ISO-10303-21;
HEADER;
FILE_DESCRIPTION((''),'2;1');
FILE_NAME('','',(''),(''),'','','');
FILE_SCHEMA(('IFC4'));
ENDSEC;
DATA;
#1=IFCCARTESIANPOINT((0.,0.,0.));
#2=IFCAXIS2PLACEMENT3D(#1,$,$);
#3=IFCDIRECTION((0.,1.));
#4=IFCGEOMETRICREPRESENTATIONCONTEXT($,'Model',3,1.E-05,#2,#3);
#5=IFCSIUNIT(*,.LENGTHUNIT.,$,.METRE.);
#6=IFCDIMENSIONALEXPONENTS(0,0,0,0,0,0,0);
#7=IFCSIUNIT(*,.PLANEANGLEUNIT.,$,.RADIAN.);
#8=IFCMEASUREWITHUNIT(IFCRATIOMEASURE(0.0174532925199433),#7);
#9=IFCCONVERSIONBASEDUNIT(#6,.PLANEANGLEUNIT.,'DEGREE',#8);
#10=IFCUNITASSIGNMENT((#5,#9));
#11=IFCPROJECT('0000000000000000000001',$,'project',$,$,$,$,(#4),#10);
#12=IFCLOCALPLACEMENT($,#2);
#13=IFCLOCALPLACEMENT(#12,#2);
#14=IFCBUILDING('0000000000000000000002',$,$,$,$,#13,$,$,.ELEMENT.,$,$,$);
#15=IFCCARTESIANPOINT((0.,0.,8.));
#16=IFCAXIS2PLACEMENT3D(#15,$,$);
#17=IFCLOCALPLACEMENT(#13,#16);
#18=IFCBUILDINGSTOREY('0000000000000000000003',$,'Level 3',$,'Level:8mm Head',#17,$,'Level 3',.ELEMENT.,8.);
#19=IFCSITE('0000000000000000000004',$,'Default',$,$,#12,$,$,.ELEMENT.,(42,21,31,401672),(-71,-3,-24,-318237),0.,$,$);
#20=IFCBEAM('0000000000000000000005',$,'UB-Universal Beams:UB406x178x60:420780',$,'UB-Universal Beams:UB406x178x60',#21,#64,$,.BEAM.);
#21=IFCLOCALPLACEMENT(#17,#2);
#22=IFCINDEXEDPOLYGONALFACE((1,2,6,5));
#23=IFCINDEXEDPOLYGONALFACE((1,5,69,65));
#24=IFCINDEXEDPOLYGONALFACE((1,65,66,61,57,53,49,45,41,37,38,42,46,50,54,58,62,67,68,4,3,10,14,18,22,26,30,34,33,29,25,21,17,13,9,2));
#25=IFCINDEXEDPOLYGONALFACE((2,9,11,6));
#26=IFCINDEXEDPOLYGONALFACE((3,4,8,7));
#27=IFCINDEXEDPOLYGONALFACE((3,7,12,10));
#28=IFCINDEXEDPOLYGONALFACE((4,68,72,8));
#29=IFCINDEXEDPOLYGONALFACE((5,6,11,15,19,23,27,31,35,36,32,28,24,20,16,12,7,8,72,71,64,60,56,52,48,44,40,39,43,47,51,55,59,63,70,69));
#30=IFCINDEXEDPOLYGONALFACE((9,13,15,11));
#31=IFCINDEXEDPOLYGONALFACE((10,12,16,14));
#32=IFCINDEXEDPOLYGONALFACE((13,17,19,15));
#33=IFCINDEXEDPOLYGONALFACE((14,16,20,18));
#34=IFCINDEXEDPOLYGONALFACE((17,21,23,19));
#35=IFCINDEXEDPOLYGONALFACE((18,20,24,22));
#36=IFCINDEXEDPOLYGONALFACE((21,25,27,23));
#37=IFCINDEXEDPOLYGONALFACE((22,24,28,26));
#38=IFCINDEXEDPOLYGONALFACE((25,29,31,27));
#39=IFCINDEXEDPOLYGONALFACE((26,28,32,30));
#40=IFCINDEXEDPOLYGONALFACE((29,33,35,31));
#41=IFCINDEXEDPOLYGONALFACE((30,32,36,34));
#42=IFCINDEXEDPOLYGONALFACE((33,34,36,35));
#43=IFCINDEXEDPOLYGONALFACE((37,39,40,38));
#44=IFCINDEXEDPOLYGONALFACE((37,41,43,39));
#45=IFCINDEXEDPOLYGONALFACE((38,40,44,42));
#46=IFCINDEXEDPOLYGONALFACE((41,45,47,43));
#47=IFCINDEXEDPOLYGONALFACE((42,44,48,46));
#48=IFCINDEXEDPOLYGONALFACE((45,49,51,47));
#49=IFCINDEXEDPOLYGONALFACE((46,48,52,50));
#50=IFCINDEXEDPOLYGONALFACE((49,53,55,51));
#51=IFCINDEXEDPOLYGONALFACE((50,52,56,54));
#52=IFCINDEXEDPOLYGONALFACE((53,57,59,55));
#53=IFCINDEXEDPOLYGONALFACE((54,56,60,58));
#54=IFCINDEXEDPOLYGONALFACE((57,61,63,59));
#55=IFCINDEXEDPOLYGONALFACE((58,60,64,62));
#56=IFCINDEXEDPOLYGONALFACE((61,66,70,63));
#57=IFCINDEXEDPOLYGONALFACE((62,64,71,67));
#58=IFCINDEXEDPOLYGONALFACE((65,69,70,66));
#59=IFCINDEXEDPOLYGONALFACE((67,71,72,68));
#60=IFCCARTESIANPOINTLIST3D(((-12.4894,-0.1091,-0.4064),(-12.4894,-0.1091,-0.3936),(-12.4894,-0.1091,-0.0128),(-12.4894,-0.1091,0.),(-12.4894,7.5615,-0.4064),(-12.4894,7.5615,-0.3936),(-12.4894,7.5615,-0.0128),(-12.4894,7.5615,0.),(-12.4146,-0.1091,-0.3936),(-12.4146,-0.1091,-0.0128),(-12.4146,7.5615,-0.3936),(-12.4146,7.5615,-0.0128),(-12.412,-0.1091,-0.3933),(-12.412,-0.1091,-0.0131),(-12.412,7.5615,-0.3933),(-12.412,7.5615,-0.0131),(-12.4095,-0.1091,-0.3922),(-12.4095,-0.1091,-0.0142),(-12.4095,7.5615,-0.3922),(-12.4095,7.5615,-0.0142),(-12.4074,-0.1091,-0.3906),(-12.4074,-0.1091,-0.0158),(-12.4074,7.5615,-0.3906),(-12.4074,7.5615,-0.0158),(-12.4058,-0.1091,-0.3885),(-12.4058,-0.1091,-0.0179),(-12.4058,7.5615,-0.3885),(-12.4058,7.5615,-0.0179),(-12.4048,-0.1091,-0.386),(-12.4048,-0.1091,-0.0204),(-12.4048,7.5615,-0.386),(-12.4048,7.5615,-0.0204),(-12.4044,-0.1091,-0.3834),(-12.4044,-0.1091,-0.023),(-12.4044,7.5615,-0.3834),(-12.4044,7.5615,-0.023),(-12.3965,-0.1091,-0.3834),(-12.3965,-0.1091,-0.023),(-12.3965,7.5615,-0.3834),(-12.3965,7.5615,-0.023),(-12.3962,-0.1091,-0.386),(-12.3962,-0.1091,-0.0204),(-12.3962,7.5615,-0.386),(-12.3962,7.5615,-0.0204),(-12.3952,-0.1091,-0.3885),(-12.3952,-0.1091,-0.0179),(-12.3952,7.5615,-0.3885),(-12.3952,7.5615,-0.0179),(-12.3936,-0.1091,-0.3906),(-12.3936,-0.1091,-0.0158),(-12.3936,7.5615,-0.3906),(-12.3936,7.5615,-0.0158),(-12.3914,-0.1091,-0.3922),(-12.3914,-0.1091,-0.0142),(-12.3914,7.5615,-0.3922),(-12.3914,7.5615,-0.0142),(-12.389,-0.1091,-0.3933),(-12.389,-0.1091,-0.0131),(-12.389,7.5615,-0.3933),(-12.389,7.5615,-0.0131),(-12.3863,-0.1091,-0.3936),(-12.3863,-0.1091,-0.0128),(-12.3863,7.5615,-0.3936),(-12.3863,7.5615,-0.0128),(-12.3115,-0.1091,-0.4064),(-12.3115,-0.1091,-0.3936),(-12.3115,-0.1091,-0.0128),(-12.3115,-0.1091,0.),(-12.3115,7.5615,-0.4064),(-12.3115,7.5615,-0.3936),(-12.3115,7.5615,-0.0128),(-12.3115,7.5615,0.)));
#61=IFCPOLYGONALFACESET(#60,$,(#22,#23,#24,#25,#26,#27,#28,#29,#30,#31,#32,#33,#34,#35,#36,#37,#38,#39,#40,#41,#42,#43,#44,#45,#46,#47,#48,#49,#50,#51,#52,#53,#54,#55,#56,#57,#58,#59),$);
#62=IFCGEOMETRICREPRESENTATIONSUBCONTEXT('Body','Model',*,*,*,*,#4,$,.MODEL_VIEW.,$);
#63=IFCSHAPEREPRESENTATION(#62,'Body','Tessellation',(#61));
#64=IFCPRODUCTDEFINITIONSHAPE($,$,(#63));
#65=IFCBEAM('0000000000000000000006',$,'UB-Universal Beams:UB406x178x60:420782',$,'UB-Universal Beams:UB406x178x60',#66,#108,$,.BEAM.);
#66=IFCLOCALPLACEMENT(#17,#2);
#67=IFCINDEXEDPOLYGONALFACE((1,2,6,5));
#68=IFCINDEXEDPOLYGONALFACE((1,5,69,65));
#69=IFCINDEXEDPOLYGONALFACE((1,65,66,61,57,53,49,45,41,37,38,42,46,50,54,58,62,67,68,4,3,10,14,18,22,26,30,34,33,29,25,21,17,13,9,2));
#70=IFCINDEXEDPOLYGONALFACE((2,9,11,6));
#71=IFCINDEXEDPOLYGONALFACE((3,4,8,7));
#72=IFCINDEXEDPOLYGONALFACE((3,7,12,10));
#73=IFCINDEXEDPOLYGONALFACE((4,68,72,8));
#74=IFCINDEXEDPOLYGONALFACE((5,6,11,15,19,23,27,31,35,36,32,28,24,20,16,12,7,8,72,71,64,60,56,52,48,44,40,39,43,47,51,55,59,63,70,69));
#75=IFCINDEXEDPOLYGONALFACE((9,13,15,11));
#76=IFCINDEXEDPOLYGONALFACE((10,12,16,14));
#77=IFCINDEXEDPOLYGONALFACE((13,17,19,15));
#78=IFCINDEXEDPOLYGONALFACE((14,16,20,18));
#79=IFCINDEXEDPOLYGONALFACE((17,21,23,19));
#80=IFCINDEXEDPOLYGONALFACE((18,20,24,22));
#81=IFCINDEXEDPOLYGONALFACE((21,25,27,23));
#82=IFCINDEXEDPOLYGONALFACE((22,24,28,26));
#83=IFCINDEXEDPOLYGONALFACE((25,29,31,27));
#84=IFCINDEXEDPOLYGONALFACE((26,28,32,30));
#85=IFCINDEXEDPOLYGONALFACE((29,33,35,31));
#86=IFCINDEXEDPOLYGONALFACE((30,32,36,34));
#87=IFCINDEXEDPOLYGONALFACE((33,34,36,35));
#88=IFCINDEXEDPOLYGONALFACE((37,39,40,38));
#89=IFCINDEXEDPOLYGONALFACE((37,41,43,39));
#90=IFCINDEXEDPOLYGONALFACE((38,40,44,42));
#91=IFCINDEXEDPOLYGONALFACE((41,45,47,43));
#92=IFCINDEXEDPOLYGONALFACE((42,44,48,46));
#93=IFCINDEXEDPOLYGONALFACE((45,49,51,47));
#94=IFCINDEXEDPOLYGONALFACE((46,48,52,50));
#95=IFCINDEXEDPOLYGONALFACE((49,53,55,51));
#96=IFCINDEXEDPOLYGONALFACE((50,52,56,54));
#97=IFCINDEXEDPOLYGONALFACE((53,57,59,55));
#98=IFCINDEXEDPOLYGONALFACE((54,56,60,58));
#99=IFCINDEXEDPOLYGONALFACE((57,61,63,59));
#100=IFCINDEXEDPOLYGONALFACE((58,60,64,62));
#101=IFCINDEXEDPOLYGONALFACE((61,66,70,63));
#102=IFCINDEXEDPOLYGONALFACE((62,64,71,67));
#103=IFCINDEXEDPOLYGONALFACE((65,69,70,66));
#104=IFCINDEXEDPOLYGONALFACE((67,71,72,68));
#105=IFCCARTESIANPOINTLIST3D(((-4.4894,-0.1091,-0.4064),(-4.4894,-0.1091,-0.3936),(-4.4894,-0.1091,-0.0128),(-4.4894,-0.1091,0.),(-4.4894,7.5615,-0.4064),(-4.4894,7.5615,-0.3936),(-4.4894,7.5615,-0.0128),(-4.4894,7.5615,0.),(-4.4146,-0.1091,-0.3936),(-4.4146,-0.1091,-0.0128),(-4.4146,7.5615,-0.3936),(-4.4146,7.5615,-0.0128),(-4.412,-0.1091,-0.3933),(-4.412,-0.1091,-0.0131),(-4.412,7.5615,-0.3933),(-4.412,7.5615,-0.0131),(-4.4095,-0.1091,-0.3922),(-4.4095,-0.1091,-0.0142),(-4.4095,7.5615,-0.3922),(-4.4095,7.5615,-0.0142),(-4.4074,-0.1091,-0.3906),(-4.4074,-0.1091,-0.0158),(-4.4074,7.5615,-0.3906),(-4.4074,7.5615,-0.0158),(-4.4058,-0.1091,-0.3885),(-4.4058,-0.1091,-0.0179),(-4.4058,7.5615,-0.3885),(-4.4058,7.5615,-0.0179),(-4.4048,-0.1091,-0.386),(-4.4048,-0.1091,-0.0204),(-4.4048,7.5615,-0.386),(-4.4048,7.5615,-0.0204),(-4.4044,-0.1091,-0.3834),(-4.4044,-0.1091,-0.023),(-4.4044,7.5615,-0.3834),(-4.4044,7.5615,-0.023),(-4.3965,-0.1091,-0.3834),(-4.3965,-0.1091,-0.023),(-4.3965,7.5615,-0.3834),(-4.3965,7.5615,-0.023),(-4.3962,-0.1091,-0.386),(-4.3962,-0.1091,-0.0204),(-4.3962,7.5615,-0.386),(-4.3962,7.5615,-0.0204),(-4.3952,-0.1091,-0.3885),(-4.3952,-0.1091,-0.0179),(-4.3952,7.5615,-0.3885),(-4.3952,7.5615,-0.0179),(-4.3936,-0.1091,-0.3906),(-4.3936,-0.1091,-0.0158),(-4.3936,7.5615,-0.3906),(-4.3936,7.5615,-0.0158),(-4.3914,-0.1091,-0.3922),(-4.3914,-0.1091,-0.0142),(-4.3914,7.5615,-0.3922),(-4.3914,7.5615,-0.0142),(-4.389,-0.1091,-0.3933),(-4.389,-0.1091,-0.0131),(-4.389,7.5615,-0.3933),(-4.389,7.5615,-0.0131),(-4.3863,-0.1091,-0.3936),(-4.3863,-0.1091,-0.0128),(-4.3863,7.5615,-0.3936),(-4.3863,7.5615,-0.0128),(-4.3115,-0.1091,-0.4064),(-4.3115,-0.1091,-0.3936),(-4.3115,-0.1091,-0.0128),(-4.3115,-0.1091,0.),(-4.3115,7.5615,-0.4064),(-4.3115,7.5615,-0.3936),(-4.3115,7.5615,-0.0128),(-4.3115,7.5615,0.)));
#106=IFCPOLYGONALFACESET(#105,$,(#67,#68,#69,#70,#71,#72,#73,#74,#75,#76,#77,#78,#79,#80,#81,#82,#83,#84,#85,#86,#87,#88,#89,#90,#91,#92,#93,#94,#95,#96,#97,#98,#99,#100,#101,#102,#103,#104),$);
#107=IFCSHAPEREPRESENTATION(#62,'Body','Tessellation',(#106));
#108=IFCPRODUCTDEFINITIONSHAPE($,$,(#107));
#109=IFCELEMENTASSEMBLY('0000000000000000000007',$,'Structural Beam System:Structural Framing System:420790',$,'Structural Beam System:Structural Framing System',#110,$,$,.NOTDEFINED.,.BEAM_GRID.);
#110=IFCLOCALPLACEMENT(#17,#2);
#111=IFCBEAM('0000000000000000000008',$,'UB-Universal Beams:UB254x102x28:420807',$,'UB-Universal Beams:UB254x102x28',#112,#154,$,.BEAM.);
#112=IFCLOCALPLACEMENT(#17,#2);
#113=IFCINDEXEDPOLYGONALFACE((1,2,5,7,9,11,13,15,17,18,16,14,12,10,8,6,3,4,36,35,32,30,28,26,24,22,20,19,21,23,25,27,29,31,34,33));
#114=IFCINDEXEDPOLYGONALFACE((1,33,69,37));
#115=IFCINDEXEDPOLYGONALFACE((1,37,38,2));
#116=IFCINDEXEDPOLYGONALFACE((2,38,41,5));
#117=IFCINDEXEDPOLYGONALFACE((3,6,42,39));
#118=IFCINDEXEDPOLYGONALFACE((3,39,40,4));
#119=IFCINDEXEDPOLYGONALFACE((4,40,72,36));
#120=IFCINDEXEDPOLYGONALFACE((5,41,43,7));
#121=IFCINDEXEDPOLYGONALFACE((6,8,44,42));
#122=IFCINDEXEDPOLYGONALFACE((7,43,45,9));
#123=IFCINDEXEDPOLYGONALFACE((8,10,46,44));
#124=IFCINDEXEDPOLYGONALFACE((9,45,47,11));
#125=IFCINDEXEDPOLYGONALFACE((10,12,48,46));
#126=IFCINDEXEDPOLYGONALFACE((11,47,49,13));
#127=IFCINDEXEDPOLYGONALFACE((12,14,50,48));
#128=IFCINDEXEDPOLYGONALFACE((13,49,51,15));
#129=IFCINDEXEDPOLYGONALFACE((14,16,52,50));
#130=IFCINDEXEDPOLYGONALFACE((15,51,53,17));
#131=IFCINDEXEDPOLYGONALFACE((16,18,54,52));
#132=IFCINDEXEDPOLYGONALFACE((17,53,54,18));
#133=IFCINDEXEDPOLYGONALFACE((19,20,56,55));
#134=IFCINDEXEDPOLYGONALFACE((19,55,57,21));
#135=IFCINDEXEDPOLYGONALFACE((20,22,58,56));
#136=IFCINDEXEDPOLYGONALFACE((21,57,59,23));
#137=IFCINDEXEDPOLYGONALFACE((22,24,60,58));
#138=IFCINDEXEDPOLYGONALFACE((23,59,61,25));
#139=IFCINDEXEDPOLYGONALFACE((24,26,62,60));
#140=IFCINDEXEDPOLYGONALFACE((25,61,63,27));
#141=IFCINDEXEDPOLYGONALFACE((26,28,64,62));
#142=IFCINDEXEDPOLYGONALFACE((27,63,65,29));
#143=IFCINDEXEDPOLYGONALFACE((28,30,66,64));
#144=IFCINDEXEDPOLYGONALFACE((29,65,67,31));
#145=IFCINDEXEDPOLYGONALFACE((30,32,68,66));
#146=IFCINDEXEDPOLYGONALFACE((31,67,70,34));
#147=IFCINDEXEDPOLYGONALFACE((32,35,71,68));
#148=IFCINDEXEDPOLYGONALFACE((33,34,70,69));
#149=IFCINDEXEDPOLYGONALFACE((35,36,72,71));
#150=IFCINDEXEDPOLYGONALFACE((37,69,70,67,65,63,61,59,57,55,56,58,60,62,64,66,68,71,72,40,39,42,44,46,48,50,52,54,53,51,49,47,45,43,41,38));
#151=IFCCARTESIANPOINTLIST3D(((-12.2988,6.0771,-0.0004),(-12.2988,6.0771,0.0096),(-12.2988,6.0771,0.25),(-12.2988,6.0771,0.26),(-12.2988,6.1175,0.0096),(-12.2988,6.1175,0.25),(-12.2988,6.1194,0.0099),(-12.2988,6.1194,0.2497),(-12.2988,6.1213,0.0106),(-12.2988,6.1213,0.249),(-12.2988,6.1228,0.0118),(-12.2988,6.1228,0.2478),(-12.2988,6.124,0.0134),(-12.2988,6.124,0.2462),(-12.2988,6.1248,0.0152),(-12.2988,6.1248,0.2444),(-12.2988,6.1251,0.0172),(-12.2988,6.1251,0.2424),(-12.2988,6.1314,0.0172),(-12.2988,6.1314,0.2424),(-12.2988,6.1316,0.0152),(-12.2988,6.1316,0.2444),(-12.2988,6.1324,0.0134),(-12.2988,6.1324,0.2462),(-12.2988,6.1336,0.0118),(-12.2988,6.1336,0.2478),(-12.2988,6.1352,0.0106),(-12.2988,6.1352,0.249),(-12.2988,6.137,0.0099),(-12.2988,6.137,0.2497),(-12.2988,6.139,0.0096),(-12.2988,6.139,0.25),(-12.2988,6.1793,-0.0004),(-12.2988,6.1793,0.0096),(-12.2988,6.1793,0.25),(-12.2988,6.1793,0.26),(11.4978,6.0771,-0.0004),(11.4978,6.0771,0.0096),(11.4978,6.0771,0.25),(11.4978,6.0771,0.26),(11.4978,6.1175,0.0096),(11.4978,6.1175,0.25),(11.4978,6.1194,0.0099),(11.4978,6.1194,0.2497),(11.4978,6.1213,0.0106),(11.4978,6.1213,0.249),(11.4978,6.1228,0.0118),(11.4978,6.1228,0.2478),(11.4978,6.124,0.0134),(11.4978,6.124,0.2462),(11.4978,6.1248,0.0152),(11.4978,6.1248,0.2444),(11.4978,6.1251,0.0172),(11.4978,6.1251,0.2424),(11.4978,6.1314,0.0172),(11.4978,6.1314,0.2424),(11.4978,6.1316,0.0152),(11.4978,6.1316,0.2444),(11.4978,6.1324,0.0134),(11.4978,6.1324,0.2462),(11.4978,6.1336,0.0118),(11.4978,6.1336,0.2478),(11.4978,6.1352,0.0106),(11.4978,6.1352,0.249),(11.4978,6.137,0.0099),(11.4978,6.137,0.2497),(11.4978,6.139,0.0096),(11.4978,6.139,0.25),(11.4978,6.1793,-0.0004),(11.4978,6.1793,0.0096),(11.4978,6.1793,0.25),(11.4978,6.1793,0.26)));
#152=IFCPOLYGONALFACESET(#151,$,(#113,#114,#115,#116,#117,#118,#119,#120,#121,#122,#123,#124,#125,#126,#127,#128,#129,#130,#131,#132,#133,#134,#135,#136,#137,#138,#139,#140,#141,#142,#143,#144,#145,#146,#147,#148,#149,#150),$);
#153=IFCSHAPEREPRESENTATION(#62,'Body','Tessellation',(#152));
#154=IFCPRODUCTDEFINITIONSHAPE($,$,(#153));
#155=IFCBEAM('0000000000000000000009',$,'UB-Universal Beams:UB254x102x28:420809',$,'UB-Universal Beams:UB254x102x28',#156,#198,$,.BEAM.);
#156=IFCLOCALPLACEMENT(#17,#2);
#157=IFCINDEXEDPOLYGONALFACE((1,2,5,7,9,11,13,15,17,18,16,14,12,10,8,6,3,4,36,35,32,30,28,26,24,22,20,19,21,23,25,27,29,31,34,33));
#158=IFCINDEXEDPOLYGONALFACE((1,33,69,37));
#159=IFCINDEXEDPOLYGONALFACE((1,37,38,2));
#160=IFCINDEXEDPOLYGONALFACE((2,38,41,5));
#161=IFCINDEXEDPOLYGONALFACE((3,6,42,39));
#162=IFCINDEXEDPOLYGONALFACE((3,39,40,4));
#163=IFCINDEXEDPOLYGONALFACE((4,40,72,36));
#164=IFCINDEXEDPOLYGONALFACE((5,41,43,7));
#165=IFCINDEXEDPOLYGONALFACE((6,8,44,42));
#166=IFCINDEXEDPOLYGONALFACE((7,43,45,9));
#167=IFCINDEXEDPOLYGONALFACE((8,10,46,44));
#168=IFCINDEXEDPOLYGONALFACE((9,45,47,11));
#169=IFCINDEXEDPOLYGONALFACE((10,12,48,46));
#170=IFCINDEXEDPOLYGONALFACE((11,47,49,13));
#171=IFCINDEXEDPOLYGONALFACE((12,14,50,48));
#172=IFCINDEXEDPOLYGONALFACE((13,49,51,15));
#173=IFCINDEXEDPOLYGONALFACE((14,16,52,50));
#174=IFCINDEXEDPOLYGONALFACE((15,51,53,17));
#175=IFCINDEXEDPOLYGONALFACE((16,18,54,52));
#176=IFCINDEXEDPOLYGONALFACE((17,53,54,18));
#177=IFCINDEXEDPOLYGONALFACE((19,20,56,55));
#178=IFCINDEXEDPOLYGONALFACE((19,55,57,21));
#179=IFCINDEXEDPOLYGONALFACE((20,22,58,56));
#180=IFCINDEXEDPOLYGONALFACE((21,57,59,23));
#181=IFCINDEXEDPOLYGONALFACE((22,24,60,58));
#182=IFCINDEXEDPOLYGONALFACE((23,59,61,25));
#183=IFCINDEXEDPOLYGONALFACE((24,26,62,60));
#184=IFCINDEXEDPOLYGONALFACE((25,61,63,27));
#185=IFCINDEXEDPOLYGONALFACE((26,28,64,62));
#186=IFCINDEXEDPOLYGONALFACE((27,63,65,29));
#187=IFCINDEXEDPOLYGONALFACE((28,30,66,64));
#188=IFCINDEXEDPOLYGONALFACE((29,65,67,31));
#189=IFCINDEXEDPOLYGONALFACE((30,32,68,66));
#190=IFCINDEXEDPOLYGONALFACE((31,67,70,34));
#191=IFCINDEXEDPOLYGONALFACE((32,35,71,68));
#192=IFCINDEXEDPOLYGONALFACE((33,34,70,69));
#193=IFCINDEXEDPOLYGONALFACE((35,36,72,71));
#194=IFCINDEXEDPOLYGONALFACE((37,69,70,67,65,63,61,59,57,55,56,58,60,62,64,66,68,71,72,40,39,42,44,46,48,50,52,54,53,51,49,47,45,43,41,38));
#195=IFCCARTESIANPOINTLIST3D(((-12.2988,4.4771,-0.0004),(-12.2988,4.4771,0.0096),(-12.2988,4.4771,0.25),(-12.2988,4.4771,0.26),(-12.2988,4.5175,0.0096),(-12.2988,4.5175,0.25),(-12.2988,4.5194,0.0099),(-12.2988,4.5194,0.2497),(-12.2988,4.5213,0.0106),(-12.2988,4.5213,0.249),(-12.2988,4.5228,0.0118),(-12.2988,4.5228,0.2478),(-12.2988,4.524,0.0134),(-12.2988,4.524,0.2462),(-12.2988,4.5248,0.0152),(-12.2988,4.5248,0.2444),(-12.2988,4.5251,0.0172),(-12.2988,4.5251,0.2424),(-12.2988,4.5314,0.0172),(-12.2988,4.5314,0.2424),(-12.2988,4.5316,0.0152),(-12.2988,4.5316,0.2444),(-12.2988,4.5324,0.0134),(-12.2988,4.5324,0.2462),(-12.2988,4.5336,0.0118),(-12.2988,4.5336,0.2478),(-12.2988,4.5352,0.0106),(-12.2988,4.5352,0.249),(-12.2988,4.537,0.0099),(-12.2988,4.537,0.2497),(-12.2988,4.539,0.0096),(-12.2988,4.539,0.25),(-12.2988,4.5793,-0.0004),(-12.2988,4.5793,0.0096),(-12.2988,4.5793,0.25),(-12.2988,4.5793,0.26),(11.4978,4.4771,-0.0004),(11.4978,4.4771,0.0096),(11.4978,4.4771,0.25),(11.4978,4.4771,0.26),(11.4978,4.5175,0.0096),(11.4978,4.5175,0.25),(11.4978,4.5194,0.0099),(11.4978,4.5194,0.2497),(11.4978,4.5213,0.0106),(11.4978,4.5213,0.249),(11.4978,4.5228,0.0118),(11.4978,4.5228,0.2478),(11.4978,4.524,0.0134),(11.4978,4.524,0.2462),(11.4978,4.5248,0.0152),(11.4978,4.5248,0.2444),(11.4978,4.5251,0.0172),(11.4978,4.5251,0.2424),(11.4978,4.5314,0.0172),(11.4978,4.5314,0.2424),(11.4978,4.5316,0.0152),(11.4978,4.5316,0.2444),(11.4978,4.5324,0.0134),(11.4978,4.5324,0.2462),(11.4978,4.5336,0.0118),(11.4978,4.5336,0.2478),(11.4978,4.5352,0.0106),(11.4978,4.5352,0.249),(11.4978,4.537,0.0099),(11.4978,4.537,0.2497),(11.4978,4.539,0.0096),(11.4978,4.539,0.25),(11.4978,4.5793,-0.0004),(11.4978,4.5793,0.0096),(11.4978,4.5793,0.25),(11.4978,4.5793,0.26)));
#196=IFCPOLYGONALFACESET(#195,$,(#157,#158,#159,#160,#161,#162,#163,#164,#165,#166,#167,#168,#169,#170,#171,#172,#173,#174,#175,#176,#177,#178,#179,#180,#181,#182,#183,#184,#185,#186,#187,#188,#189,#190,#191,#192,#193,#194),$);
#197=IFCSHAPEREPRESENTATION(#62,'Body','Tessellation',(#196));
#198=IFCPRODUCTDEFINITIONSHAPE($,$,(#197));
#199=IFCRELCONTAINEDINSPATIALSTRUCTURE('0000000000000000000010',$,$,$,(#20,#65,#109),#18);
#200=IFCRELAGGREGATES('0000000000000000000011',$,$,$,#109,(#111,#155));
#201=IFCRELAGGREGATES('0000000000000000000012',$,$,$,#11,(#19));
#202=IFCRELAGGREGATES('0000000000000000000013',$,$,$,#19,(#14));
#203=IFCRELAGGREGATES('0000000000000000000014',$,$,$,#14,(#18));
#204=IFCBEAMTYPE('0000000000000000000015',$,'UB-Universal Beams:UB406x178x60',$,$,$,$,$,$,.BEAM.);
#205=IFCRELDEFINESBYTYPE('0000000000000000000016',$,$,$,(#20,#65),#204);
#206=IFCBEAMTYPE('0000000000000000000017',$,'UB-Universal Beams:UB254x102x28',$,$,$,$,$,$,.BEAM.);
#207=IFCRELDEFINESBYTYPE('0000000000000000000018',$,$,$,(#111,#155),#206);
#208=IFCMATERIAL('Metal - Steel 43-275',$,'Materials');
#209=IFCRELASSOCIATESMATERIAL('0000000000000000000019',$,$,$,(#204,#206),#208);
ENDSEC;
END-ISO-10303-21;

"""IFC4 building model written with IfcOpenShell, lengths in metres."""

from ifc_helpers import new_model, entity, si_unit, converted_unit, direction, frame, frame_2d, origin, place, context, subcontext, project, spatial, i_section, extrude, source, transform, mapped, material, material_profile, profile_set, type_object, type_shapes, element, aggregate, save


model = new_model("IFC4")

# Units and contexts
model_context = context("Model", 3, precision=1e-05, world=origin(), true_north=direction((0.0, 1.0)))
body_context = subcontext(model_context, "Body", "Model", "MODEL_VIEW")
ifc_project = project(units=[si_unit("LENGTHUNIT", "METRE"), converted_unit("PLANEANGLEUNIT", "DEGREE", entity("IfcRatioMeasure", 0.0174532925199433), si_unit("PLANEANGLEUNIT", "RADIAN"), dimensions=[0, 0, 0, 0, 0, 0, 0])], contexts=[model_context])

# Site, building, storey
site_placement = place(None, origin())
site = spatial("IfcSite", under=ifc_project, at=site_placement, Name="Default", CompositionType="ELEMENT", RefLatitude=(42, 21, 31, 401672), RefLongitude=(-71, -3, -24, -318237), RefElevation=0.0)
building_placement = place(site_placement, origin())
building = spatial("IfcBuilding", under=site, at=building_placement, CompositionType="ELEMENT")
storey_placement = place(building_placement, frame((0.0, 0.0, 8.0)))
storey = spatial("IfcBuildingStorey", under=building, at=storey_placement, Name="Level 3", ObjectType="Level:8mm Head", LongName="Level 3", CompositionType="ELEMENT", Elevation=8.0)

# Beams
ifc_material_1 = material(Name="Metal - Steel 43-275", Category="Materials")
ifc_material_profile_1 = material_profile(ifc_material_1, i_section(OverallWidth=0.1779, OverallDepth=0.4064, WebThickness=0.0079, FlangeThickness=0.0128, FilletRadius=0.0102, at=frame_2d((0.0, 0.0), x_axis=(0.0, 1.0))), Name="UB406x178x60")
ifc_profile_set_1 = profile_set([ifc_material_profile_1], Name="UB406x178x60")
beam_type_1 = type_object("IfcBeamType", Name="UB-Universal Beams:UB406x178x60", PredefinedType="BEAM", material=ifc_profile_set_1)
shared_shape_1 = source(origin(), body_context, "Body", "SweptSolid", [
    extrude(i_section(OverallWidth=0.1779, OverallDepth=0.4064, WebThickness=0.0079, FlangeThickness=0.0128, FilletRadius=0.0102, at=frame_2d((0.0, 0.0), x_axis=(0.0, 1.0))), frame((-3.8373, 0.0, 0.0), z_axis=(1.0, 0.0, 0.0), x_axis=(0.0, 0.0, -1.0)), (0.0, 0.0, 1.0), 7.6706),
])
type_shapes(beam_type_1, [shared_shape_1])
for number, where, z_axis, x_axis, name in (
    (1, (-12.4005, 3.7282, -0.2032), (0.0, 0.0, 1.0), (0.0, 1.0, 0.0), "UB-Universal Beams:UB406x178x60:420780"),
    (2, (-4.4005, 3.7282, -0.2032), (0.0, 0.0, 1.0), (0.0, 1.0, 0.0), "UB-Universal Beams:UB406x178x60:420782"),
):
    element("IfcBeam", number, at=place(storey_placement, frame(where, z_axis=z_axis, x_axis=x_axis)), inside=storey, type_object=beam_type_1, Name=name, ObjectType="UB-Universal Beams:UB406x178x60", PredefinedType="BEAM", context=body_context, shape_type="MappedRepresentation", body=[
        mapped(shared_shape_1, transform((0.0, 0.0, 0.0), scale=1.0)),
    ])

# Element assembly, beams
assembly_placement = place(storey_placement, origin())
assembly = element("IfcElementAssembly", 3, at=assembly_placement, inside=storey, Name="Structural Beam System:Structural Framing System:420790", ObjectType="Structural Beam System:Structural Framing System", AssemblyPlace="NOTDEFINED", PredefinedType="BEAM_GRID")
ifc_material_profile_2 = material_profile(ifc_material_1, i_section(OverallWidth=0.1022, OverallDepth=0.2604, WebThickness=0.0063, FlangeThickness=0.01, FilletRadius=0.0076, at=frame_2d((0.0, 0.0), x_axis=(0.0, 1.0))), Name="UB254x102x28")
ifc_profile_set_2 = profile_set([ifc_material_profile_2], Name="UB254x102x28")
beam_type_2 = type_object("IfcBeamType", Name="UB-Universal Beams:UB254x102x28", PredefinedType="BEAM", material=ifc_profile_set_2)
shared_shape_2 = source(origin(), body_context, "Body", "SweptSolid", [
    extrude(i_section(OverallWidth=0.1022, OverallDepth=0.2604, WebThickness=0.0063, FlangeThickness=0.01, FilletRadius=0.0076, at=frame_2d((0.0, 0.0), x_axis=(0.0, 1.0))), frame((-11.8983, 0.0, 0.0), z_axis=(1.0, 0.0, 0.0), x_axis=(0.0, 0.0, -1.0)), (0.0, 0.0, 1.0), 23.7966),
])
type_shapes(beam_type_2, [shared_shape_2])
beam_1_placement = place(assembly_placement, frame((-0.4005, 6.1282, 0.1298)))
beam_1 = element("IfcBeam", 4, at=beam_1_placement, type_object=beam_type_2, Name="UB-Universal Beams:UB254x102x28:420807", ObjectType="UB-Universal Beams:UB254x102x28", PredefinedType="BEAM", context=body_context, shape_type="MappedRepresentation", body=[
    mapped(shared_shape_2, transform((0.0, 0.0, 0.0), scale=1.0)),
])
beam_2_placement = place(assembly_placement, frame((-0.4005, 4.5282, 0.1298)))
beam_2 = element("IfcBeam", 5, at=beam_2_placement, type_object=beam_type_2, Name="UB-Universal Beams:UB254x102x28:420809", ObjectType="UB-Universal Beams:UB254x102x28", PredefinedType="BEAM", context=body_context, shape_type="MappedRepresentation", body=[
    mapped(shared_shape_2, transform((0.0, 0.0, 0.0), scale=1.0)),
])
aggregate(assembly, [beam_1, beam_2])

save(model, "model.ifc")
